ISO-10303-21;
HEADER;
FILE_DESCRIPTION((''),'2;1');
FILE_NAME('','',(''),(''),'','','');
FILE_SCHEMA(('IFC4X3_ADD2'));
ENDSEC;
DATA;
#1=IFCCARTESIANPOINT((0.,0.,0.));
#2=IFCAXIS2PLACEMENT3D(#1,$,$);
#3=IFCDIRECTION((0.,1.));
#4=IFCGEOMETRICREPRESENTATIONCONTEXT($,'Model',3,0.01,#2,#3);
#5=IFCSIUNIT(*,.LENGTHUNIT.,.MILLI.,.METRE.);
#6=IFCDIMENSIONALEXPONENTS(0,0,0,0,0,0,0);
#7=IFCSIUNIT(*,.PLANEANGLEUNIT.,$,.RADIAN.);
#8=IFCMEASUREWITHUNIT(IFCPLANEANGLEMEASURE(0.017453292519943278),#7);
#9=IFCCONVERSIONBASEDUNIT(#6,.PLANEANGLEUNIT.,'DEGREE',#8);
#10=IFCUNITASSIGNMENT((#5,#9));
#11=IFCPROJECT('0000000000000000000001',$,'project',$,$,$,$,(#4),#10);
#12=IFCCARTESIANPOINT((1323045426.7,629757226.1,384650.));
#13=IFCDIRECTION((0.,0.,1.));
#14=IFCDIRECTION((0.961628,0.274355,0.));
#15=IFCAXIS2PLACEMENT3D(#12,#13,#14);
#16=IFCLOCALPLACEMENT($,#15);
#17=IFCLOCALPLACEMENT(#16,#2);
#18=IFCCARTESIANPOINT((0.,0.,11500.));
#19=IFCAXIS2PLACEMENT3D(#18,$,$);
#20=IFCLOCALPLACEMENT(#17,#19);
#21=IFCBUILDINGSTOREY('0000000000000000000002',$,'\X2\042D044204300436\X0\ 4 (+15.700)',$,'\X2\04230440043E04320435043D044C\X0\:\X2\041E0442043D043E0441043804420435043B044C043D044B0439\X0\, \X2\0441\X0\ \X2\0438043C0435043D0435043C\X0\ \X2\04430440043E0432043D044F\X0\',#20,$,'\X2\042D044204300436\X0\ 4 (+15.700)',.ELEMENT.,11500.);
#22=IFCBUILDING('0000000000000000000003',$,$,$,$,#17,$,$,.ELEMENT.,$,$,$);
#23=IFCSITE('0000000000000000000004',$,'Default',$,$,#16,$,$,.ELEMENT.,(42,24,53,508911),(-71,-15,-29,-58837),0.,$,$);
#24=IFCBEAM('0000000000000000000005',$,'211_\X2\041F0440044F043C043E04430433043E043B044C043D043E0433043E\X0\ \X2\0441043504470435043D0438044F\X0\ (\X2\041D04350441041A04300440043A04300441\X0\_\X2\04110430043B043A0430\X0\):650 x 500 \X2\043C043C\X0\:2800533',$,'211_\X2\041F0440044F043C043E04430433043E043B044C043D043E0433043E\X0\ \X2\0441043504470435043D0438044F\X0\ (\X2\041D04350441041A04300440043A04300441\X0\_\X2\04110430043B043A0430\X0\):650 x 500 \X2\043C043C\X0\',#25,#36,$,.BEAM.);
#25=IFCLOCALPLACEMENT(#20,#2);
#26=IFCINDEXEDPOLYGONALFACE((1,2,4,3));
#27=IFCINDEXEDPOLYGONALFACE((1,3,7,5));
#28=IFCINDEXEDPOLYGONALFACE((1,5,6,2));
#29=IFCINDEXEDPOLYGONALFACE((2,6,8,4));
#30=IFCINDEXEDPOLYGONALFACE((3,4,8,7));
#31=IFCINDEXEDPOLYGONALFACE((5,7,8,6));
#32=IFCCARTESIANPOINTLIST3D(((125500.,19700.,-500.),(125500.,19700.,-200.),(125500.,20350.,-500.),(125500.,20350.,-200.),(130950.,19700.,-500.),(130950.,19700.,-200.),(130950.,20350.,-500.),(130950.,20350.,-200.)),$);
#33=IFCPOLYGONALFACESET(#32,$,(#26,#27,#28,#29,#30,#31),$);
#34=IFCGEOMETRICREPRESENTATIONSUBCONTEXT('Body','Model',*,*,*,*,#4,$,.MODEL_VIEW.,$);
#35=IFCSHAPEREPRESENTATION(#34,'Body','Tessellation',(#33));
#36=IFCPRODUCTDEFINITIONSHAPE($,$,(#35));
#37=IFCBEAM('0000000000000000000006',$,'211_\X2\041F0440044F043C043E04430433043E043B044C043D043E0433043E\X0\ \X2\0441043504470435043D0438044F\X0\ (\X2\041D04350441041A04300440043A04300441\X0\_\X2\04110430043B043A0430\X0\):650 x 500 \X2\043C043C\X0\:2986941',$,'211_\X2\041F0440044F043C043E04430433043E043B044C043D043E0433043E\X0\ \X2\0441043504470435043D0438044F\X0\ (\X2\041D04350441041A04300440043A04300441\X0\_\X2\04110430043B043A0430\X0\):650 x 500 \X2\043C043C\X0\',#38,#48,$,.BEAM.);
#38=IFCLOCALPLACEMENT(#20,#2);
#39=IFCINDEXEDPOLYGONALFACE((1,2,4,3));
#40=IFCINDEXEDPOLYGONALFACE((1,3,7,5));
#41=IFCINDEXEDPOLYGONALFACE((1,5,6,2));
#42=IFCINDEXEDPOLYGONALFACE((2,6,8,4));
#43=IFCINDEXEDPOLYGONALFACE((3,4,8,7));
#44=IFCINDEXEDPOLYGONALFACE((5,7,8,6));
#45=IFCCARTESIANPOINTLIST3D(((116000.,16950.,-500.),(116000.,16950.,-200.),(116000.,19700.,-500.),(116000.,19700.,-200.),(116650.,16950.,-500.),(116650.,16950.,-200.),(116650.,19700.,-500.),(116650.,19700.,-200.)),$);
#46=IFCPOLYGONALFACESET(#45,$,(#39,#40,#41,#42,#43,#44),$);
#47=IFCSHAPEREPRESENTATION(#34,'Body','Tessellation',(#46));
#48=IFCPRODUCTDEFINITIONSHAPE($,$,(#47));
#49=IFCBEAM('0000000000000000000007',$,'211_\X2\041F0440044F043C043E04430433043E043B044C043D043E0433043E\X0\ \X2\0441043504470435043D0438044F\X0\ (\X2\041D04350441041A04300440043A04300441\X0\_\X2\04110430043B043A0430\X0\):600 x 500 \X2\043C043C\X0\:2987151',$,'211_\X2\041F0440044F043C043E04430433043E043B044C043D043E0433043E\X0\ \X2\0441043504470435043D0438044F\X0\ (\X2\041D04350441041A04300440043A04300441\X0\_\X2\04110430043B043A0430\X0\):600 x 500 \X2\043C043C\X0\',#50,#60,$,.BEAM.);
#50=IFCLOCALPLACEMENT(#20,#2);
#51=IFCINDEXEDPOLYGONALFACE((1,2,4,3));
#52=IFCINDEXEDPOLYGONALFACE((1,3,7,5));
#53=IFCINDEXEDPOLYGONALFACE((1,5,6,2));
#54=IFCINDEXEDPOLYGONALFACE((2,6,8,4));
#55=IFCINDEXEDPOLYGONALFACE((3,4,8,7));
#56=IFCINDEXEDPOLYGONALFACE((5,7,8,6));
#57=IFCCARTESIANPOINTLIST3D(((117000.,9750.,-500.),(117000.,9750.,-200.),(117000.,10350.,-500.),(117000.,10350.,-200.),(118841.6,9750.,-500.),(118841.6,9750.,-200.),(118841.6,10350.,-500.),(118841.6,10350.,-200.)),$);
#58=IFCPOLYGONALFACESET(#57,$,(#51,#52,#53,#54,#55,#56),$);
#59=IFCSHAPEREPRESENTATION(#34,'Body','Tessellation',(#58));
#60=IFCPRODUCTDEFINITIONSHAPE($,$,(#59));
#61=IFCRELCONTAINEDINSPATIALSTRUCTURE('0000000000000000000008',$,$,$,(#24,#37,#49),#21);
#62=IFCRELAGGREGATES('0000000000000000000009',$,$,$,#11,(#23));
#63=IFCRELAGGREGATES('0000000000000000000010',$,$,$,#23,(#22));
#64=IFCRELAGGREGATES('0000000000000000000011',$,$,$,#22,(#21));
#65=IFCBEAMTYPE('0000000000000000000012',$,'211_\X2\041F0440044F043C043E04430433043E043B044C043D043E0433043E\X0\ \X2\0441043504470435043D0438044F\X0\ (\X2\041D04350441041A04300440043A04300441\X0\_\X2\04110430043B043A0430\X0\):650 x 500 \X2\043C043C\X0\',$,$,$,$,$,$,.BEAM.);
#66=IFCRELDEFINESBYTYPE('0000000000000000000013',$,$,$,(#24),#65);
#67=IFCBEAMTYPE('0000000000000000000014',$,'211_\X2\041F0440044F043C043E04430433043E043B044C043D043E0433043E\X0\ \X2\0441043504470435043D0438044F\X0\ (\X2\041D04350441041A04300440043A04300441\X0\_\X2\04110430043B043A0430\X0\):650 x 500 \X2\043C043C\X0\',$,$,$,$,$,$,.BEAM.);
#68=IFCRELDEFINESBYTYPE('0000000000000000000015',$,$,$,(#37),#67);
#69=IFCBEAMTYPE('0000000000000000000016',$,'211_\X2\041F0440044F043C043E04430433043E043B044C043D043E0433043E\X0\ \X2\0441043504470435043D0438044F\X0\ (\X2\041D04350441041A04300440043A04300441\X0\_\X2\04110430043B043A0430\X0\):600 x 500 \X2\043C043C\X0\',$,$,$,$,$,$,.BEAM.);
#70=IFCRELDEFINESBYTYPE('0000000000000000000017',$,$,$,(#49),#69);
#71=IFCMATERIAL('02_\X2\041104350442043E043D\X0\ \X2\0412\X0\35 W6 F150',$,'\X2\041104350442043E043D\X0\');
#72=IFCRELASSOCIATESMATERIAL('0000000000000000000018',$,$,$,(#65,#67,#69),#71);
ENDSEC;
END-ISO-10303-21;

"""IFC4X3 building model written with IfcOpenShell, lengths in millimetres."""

from ifc_helpers import new_model, entity, si_unit, converted_unit, direction, frame, frame_2d, origin, place, context, subcontext, project, spatial, rectangle, extrude, source, transform, mapped, material, material_profile, profile_set, type_object, type_shapes, element, save


model = new_model("IFC4X3")

# Units and contexts
model_context = context("Model", 3, precision=0.01, world=origin(), true_north=direction((0.0, 1.0)))
body_context = subcontext(model_context, "Body", "Model", "MODEL_VIEW")
ifc_project = project(units=[si_unit("LENGTHUNIT", "METRE", prefix="MILLI"), converted_unit("PLANEANGLEUNIT", "DEGREE", entity("IfcPlaneAngleMeasure", 0.017453292519943278), si_unit("PLANEANGLEUNIT", "RADIAN"), dimensions=[0, 0, 0, 0, 0, 0, 0])], contexts=[model_context])

# Site, building, storey
site_placement = place(None, frame((1323045426.7, 629757226.1, 384650.0), z_axis=(0.0, 0.0, 1.0), x_axis=(0.961628, 0.274355, 0.0)))
site = spatial("IfcSite", under=ifc_project, at=site_placement, Name="Default", CompositionType="ELEMENT", RefLatitude=(42, 24, 53, 508911), RefLongitude=(-71, -15, -29, -58837), RefElevation=0.0)
building_placement = place(site_placement, origin())
building = spatial("IfcBuilding", under=site, at=building_placement, CompositionType="ELEMENT")
storey_placement = place(building_placement, frame((0.0, 0.0, 11500.0)))
storey = spatial("IfcBuildingStorey", under=building, at=storey_placement, Name="Этаж 4 (+15.700)", ObjectType="Уровень:Относительный, с именем уровня", LongName="Этаж 4 (+15.700)", CompositionType="ELEMENT", Elevation=11500.0)

# Beams
ifc_material = material(Name="02_Бетон В35 W6 F150", Category="Бетон")
ifc_material_profile_1 = material_profile(ifc_material, rectangle(XDim=300.0, YDim=650.0, at=frame_2d((0.0, 0.0), x_axis=(1.0, 0.0))), Name="650 x 500 мм")
ifc_profile_set_1 = profile_set([ifc_material_profile_1], Name="650 x 500 мм")
beam_type_1 = type_object("IfcBeamType", Name="211_Прямоугольного сечения (НесКаркас_Балка):650 x 500 мм", PredefinedType="BEAM", material=ifc_profile_set_1)
shared_shape_1 = source(origin(), body_context, "Body", "SweptSolid", [
    extrude(rectangle(XDim=300.0, YDim=650.0, at=frame_2d((0.0, 0.0), x_axis=(1.0, 0.0))), frame((125500.0, 20025.0, 11150.0), z_axis=(1.0, 0.0, 0.0), x_axis=(0.0, 0.0, -1.0)), (0.0, 0.0, 1.0), 5450.0),
])
type_shapes(beam_type_1, [shared_shape_1])
beam_1_placement = place(storey_placement, frame((0.0, 0.0, -11500.0)))
element("IfcBeam", 1, at=beam_1_placement, inside=storey, type_object=beam_type_1, Name="211_Прямоугольного сечения (НесКаркас_Балка):650 x 500 мм:2800533", ObjectType="211_Прямоугольного сечения (НесКаркас_Балка):650 x 500 мм", PredefinedType="BEAM", context=body_context, shape_type="MappedRepresentation", body=[
    mapped(shared_shape_1, transform((0.0, 0.0, 0.0), scale=1.0)),
])
beam_type_2 = type_object("IfcBeamType", Name="211_Прямоугольного сечения (НесКаркас_Балка):650 x 500 мм", PredefinedType="BEAM", material=ifc_profile_set_1)
shared_shape_2 = source(origin(), body_context, "Body", "SweptSolid", [
    extrude(rectangle(XDim=300.0, YDim=650.0, at=frame_2d((0.0, 0.0), x_axis=(0.0, 1.0))), frame((116325.0, 19700.0, 11150.0), z_axis=(0.0, -1.0, 0.0), x_axis=(-1.0, 0.0, 0.0)), (0.0, 0.0, 1.0), 2750.0),
])
type_shapes(beam_type_2, [shared_shape_2])
beam_2_placement = place(storey_placement, frame((0.0, 0.0, -11500.0)))
element("IfcBeam", 2, at=beam_2_placement, inside=storey, type_object=beam_type_2, Name="211_Прямоугольного сечения (НесКаркас_Балка):650 x 500 мм:2986941", ObjectType="211_Прямоугольного сечения (НесКаркас_Балка):650 x 500 мм", PredefinedType="BEAM", context=body_context, shape_type="MappedRepresentation", body=[
    mapped(shared_shape_2, transform((0.0, 0.0, 0.0), scale=1.0)),
])
ifc_material_profile_2 = material_profile(ifc_material, rectangle(XDim=300.0, YDim=600.0, at=frame_2d((0.0, 0.0), x_axis=(1.0, 0.0))), Name="600 x 500 мм")
ifc_profile_set_2 = profile_set([ifc_material_profile_2], Name="600 x 500 мм")
beam_type_3 = type_object("IfcBeamType", Name="211_Прямоугольного сечения (НесКаркас_Балка):600 x 500 мм", PredefinedType="BEAM", material=ifc_profile_set_2)
shared_shape_3 = source(origin(), body_context, "Body", "SweptSolid", [
    extrude(rectangle(XDim=300.0, YDim=600.0, at=frame_2d((0.0, 0.0), x_axis=(1.0, 0.0))), frame((117000.0, 10050.0, 11150.0), z_axis=(1.0, 0.0, 0.0), x_axis=(0.0, 0.0, -1.0)), (0.0, 0.0, 1.0), 1841.6),
])
type_shapes(beam_type_3, [shared_shape_3])
beam_3_placement = place(storey_placement, frame((0.0, 0.0, -11500.0)))
element("IfcBeam", 3, at=beam_3_placement, inside=storey, type_object=beam_type_3, Name="211_Прямоугольного сечения (НесКаркас_Балка):600 x 500 мм:2987151", ObjectType="211_Прямоугольного сечения (НесКаркас_Балка):600 x 500 мм", PredefinedType="BEAM", context=body_context, shape_type="MappedRepresentation", body=[
    mapped(shared_shape_3, transform((0.0, 0.0, 0.0), scale=1.0)),
])

save(model, "model.ifc")
